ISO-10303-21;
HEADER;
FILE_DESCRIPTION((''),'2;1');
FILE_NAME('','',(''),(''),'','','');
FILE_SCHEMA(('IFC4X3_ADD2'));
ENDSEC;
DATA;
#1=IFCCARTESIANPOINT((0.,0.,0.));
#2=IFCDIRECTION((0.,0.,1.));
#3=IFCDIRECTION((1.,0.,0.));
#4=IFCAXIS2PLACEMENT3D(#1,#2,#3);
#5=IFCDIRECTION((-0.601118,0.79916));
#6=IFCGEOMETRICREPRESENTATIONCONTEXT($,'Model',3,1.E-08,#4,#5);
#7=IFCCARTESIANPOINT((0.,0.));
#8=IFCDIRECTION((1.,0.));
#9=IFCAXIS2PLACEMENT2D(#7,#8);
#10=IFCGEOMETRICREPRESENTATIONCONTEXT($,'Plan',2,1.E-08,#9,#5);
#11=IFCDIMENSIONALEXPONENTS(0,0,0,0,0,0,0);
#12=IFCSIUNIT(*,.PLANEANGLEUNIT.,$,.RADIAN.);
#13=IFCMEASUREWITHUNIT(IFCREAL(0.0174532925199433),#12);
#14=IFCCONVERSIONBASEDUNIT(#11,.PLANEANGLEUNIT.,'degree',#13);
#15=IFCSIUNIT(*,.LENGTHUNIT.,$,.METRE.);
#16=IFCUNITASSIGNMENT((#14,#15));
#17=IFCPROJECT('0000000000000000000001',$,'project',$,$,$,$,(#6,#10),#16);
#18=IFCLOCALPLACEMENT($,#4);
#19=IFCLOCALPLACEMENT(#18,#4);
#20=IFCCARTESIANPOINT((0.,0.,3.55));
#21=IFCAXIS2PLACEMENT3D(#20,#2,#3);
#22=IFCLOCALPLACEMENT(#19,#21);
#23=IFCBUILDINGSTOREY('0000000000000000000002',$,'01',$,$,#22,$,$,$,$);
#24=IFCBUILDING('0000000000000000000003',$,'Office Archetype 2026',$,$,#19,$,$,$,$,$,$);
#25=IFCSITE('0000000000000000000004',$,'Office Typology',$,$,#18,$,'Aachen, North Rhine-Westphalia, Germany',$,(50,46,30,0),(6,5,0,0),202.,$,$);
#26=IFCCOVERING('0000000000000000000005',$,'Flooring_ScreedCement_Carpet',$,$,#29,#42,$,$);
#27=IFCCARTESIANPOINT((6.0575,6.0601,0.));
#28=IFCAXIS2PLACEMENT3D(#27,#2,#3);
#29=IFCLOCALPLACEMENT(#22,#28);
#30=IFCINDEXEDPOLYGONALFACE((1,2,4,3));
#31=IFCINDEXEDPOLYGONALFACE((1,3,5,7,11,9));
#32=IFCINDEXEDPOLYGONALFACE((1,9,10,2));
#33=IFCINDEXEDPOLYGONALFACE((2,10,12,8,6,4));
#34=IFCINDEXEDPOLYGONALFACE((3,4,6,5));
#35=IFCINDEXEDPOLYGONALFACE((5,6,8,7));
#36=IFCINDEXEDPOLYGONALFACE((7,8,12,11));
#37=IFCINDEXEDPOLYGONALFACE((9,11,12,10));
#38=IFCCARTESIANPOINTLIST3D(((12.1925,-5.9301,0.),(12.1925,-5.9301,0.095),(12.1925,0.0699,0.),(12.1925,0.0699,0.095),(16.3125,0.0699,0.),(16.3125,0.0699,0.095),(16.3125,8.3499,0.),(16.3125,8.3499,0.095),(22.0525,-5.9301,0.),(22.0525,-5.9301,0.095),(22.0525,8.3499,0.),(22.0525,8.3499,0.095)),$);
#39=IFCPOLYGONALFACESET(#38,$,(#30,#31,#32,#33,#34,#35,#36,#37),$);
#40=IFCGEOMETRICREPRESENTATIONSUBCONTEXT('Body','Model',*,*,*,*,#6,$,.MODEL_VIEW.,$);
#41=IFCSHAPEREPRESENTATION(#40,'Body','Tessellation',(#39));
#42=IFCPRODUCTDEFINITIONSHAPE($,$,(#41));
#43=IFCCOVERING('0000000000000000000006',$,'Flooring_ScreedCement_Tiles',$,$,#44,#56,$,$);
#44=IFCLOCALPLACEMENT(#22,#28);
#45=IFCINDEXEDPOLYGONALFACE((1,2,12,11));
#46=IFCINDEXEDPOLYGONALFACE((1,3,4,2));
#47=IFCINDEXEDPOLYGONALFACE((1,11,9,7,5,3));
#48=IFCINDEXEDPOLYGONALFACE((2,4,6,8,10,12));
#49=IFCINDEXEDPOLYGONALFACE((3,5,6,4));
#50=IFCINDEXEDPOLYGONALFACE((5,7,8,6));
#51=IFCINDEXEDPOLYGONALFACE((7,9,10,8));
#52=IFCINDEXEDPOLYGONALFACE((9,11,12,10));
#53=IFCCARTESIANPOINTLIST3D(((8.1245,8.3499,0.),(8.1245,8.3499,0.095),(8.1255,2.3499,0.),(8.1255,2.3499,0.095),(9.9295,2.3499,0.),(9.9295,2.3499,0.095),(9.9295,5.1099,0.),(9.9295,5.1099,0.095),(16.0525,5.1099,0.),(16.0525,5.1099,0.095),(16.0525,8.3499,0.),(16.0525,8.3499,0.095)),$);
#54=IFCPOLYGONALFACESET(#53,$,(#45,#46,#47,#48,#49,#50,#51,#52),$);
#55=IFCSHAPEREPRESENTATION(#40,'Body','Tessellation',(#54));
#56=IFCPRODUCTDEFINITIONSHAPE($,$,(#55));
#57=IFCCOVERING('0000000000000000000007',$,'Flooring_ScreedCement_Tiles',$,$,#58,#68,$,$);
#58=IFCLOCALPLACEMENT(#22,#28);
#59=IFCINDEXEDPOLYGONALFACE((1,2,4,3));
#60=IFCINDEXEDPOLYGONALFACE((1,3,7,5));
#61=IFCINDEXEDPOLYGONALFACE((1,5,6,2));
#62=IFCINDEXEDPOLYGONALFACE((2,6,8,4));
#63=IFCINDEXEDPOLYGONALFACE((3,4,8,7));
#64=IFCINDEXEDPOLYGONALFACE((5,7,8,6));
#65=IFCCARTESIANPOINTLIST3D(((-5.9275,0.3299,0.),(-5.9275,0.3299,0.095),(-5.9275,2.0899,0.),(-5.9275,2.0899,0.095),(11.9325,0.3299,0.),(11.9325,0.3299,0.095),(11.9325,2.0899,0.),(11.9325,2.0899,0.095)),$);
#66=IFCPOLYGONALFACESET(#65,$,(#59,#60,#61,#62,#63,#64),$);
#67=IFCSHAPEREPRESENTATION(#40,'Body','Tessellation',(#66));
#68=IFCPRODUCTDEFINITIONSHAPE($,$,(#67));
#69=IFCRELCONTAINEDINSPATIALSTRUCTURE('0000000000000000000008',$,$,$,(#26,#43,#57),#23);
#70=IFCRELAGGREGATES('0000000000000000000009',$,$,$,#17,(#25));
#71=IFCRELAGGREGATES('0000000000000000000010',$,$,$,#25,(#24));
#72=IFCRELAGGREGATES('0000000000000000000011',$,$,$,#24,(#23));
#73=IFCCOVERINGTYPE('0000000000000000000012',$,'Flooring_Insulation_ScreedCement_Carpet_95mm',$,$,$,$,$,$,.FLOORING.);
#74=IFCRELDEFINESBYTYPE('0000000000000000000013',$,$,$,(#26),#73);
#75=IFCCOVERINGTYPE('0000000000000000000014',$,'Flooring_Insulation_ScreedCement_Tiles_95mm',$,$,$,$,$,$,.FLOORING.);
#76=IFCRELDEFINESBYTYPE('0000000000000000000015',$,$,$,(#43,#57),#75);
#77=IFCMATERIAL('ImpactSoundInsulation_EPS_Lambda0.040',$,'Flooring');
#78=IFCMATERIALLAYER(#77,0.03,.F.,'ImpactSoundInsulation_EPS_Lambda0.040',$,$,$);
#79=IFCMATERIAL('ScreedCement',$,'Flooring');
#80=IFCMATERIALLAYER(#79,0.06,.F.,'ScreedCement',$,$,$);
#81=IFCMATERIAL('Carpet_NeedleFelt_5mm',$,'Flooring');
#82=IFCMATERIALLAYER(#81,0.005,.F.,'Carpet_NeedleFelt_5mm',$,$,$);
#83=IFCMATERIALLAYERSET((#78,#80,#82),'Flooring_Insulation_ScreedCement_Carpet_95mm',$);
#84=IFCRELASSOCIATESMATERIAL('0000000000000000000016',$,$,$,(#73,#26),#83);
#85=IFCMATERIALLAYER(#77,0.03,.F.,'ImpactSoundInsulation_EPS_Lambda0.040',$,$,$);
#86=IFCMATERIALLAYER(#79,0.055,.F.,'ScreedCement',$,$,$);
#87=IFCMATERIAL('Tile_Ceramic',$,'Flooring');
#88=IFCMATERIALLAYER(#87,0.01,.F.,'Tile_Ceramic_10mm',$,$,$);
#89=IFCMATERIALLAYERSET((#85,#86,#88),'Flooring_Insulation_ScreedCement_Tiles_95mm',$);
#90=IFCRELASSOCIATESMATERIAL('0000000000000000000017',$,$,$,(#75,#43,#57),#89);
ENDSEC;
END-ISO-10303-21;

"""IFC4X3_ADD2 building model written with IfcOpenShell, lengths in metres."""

from ifc_helpers import new_model, entity, si_unit, converted_unit, direction, frame, origin_with_axes, origin_2d_with_axis, place, context, subcontext, project, spatial, line, indexed_curve, outline, extrude, material, layer, layer_set, layer_usage, type_object, element, save


model = new_model("IFC4X3_ADD2")

# Units and contexts
model_context = context("Model", 3, precision=1e-08, world=origin_with_axes(), true_north=direction((-0.601118, 0.79916)))
plan_context = context("Plan", 2, precision=1e-08, world=origin_2d_with_axis(), true_north=direction((-0.601118, 0.79916)))
body_context = subcontext(model_context, "Body", "Model", "MODEL_VIEW")
ifc_project = project(units=[converted_unit("PLANEANGLEUNIT", "degree", entity("IfcReal", 0.0174532925199433), si_unit("PLANEANGLEUNIT", "RADIAN"), dimensions=[0, 0, 0, 0, 0, 0, 0]), si_unit("LENGTHUNIT", "METRE")], contexts=[model_context, plan_context])

# Site, building, storey
site_placement = place(None, origin_with_axes())
site = spatial("IfcSite", under=ifc_project, at=site_placement, Name="Office Typology", LongName="Aachen, North Rhine-Westphalia, Germany", RefLatitude=(50, 46, 30, 0), RefLongitude=(6, 5, 0, 0), RefElevation=202.0)
building_placement = place(site_placement, origin_with_axes())
building = spatial("IfcBuilding", under=site, at=building_placement, Name="Office Archetype 2026")
storey_placement = place(building_placement, frame((0.0, 0.0, 3.55), z_axis=(0.0, 0.0, 1.0), x_axis=(1.0, 0.0, 0.0)))
storey = spatial("IfcBuildingStorey", under=building, at=storey_placement, Name="01")

# Coverings
ifc_material_1 = material(Name="ImpactSoundInsulation_EPS_Lambda0.040", Category="Flooring")
ifc_layer_1 = layer(ifc_material_1, 0.03, ventilated=False, Name="ImpactSoundInsulation_EPS_Lambda0.040")
ifc_material_2 = material(Name="ScreedCement", Category="Flooring")
ifc_layer_2 = layer(ifc_material_2, 0.06, ventilated=False, Name="ScreedCement")
ifc_material_3 = material(Name="Carpet_NeedleFelt_5mm", Category="Flooring")
ifc_layer_3 = layer(ifc_material_3, 0.005, ventilated=False, Name="Carpet_NeedleFelt_5mm")
ifc_layer_set_1 = layer_set([ifc_layer_1, ifc_layer_2, ifc_layer_3], Name="Flooring_Insulation_ScreedCement_Carpet_95mm")
ifc_layer_usage_1 = layer_usage(ifc_layer_set_1, "AXIS3", "POSITIVE", 0.0)
covering_type_1 = type_object("IfcCoveringType", Name="Flooring_Insulation_ScreedCement_Carpet_95mm", PredefinedType="FLOORING", material=ifc_layer_set_1)
covering_1_placement = place(storey_placement, frame((6.0575, 6.0601, 0.0), z_axis=(0.0, 0.0, 1.0), x_axis=(1.0, 0.0, 0.0)))
element("IfcCovering", 1, at=covering_1_placement, inside=storey, type_object=covering_type_1, material=ifc_layer_usage_1, Name="Flooring_ScreedCement_Carpet", context=body_context, shape_type="SweptSolid", body=[
    extrude(outline(indexed_curve([(16.3125, 8.3499), (22.0525, 8.3499), (22.0525, -5.9301), (12.1925, -5.9301), (12.1925, 0.0699), (16.3125, 0.0699)], segments=[line(1, 2, 3, 4, 5, 6, 1)])), origin_with_axes(), (0.0, 0.0, 1.0), 0.095),
])
ifc_layer_4 = layer(ifc_material_1, 0.03, ventilated=False, Name="ImpactSoundInsulation_EPS_Lambda0.040")
ifc_layer_5 = layer(ifc_material_2, 0.055, ventilated=False, Name="ScreedCement")
ifc_material_4 = material(Name="Tile_Ceramic", Category="Flooring")
ifc_layer_6 = layer(ifc_material_4, 0.01, ventilated=False, Name="Tile_Ceramic_10mm")
ifc_layer_set_2 = layer_set([ifc_layer_4, ifc_layer_5, ifc_layer_6], Name="Flooring_Insulation_ScreedCement_Tiles_95mm")
ifc_layer_usage_2 = layer_usage(ifc_layer_set_2, "AXIS3", "POSITIVE", 0.0)
covering_type_2 = type_object("IfcCoveringType", Name="Flooring_Insulation_ScreedCement_Tiles_95mm", PredefinedType="FLOORING", material=ifc_layer_set_2)
covering_2_placement = place(storey_placement, frame((6.0575, 6.0601, 0.0), z_axis=(0.0, 0.0, 1.0), x_axis=(1.0, 0.0, 0.0)))
element("IfcCovering", 2, at=covering_2_placement, inside=storey, type_object=covering_type_2, material=ifc_layer_usage_2, Name="Flooring_ScreedCement_Tiles", context=body_context, shape_type="SweptSolid", body=[
    extrude(outline(indexed_curve([(9.9295, 2.3499), (8.1255, 2.3499), (8.1245, 8.3499), (16.0525, 8.3499), (16.0525, 5.1099), (9.9295, 5.1099)], segments=[line(1, 2, 3, 4, 5, 6, 1)])), None, (0.0, 0.0, 1.0), 0.095),
])
ifc_layer_usage_3 = layer_usage(ifc_layer_set_2, "AXIS3", "POSITIVE", 0.0)
covering_3_placement = place(storey_placement, frame((6.0575, 6.0601, 0.0), z_axis=(0.0, 0.0, 1.0), x_axis=(1.0, 0.0, 0.0)))
element("IfcCovering", 3, at=covering_3_placement, inside=storey, type_object=covering_type_2, material=ifc_layer_usage_3, Name="Flooring_ScreedCement_Tiles", context=body_context, shape_type="SweptSolid", body=[
    extrude(outline(indexed_curve([(-5.9275, 0.3299), (-5.9275, 2.0899), (11.9325, 2.0899), (11.9325, 0.3299)], segments=[line(1, 2, 3, 4, 1)])), None, (0.0, 0.0, 1.0), 0.095),
])

save(model, "model.ifc")
